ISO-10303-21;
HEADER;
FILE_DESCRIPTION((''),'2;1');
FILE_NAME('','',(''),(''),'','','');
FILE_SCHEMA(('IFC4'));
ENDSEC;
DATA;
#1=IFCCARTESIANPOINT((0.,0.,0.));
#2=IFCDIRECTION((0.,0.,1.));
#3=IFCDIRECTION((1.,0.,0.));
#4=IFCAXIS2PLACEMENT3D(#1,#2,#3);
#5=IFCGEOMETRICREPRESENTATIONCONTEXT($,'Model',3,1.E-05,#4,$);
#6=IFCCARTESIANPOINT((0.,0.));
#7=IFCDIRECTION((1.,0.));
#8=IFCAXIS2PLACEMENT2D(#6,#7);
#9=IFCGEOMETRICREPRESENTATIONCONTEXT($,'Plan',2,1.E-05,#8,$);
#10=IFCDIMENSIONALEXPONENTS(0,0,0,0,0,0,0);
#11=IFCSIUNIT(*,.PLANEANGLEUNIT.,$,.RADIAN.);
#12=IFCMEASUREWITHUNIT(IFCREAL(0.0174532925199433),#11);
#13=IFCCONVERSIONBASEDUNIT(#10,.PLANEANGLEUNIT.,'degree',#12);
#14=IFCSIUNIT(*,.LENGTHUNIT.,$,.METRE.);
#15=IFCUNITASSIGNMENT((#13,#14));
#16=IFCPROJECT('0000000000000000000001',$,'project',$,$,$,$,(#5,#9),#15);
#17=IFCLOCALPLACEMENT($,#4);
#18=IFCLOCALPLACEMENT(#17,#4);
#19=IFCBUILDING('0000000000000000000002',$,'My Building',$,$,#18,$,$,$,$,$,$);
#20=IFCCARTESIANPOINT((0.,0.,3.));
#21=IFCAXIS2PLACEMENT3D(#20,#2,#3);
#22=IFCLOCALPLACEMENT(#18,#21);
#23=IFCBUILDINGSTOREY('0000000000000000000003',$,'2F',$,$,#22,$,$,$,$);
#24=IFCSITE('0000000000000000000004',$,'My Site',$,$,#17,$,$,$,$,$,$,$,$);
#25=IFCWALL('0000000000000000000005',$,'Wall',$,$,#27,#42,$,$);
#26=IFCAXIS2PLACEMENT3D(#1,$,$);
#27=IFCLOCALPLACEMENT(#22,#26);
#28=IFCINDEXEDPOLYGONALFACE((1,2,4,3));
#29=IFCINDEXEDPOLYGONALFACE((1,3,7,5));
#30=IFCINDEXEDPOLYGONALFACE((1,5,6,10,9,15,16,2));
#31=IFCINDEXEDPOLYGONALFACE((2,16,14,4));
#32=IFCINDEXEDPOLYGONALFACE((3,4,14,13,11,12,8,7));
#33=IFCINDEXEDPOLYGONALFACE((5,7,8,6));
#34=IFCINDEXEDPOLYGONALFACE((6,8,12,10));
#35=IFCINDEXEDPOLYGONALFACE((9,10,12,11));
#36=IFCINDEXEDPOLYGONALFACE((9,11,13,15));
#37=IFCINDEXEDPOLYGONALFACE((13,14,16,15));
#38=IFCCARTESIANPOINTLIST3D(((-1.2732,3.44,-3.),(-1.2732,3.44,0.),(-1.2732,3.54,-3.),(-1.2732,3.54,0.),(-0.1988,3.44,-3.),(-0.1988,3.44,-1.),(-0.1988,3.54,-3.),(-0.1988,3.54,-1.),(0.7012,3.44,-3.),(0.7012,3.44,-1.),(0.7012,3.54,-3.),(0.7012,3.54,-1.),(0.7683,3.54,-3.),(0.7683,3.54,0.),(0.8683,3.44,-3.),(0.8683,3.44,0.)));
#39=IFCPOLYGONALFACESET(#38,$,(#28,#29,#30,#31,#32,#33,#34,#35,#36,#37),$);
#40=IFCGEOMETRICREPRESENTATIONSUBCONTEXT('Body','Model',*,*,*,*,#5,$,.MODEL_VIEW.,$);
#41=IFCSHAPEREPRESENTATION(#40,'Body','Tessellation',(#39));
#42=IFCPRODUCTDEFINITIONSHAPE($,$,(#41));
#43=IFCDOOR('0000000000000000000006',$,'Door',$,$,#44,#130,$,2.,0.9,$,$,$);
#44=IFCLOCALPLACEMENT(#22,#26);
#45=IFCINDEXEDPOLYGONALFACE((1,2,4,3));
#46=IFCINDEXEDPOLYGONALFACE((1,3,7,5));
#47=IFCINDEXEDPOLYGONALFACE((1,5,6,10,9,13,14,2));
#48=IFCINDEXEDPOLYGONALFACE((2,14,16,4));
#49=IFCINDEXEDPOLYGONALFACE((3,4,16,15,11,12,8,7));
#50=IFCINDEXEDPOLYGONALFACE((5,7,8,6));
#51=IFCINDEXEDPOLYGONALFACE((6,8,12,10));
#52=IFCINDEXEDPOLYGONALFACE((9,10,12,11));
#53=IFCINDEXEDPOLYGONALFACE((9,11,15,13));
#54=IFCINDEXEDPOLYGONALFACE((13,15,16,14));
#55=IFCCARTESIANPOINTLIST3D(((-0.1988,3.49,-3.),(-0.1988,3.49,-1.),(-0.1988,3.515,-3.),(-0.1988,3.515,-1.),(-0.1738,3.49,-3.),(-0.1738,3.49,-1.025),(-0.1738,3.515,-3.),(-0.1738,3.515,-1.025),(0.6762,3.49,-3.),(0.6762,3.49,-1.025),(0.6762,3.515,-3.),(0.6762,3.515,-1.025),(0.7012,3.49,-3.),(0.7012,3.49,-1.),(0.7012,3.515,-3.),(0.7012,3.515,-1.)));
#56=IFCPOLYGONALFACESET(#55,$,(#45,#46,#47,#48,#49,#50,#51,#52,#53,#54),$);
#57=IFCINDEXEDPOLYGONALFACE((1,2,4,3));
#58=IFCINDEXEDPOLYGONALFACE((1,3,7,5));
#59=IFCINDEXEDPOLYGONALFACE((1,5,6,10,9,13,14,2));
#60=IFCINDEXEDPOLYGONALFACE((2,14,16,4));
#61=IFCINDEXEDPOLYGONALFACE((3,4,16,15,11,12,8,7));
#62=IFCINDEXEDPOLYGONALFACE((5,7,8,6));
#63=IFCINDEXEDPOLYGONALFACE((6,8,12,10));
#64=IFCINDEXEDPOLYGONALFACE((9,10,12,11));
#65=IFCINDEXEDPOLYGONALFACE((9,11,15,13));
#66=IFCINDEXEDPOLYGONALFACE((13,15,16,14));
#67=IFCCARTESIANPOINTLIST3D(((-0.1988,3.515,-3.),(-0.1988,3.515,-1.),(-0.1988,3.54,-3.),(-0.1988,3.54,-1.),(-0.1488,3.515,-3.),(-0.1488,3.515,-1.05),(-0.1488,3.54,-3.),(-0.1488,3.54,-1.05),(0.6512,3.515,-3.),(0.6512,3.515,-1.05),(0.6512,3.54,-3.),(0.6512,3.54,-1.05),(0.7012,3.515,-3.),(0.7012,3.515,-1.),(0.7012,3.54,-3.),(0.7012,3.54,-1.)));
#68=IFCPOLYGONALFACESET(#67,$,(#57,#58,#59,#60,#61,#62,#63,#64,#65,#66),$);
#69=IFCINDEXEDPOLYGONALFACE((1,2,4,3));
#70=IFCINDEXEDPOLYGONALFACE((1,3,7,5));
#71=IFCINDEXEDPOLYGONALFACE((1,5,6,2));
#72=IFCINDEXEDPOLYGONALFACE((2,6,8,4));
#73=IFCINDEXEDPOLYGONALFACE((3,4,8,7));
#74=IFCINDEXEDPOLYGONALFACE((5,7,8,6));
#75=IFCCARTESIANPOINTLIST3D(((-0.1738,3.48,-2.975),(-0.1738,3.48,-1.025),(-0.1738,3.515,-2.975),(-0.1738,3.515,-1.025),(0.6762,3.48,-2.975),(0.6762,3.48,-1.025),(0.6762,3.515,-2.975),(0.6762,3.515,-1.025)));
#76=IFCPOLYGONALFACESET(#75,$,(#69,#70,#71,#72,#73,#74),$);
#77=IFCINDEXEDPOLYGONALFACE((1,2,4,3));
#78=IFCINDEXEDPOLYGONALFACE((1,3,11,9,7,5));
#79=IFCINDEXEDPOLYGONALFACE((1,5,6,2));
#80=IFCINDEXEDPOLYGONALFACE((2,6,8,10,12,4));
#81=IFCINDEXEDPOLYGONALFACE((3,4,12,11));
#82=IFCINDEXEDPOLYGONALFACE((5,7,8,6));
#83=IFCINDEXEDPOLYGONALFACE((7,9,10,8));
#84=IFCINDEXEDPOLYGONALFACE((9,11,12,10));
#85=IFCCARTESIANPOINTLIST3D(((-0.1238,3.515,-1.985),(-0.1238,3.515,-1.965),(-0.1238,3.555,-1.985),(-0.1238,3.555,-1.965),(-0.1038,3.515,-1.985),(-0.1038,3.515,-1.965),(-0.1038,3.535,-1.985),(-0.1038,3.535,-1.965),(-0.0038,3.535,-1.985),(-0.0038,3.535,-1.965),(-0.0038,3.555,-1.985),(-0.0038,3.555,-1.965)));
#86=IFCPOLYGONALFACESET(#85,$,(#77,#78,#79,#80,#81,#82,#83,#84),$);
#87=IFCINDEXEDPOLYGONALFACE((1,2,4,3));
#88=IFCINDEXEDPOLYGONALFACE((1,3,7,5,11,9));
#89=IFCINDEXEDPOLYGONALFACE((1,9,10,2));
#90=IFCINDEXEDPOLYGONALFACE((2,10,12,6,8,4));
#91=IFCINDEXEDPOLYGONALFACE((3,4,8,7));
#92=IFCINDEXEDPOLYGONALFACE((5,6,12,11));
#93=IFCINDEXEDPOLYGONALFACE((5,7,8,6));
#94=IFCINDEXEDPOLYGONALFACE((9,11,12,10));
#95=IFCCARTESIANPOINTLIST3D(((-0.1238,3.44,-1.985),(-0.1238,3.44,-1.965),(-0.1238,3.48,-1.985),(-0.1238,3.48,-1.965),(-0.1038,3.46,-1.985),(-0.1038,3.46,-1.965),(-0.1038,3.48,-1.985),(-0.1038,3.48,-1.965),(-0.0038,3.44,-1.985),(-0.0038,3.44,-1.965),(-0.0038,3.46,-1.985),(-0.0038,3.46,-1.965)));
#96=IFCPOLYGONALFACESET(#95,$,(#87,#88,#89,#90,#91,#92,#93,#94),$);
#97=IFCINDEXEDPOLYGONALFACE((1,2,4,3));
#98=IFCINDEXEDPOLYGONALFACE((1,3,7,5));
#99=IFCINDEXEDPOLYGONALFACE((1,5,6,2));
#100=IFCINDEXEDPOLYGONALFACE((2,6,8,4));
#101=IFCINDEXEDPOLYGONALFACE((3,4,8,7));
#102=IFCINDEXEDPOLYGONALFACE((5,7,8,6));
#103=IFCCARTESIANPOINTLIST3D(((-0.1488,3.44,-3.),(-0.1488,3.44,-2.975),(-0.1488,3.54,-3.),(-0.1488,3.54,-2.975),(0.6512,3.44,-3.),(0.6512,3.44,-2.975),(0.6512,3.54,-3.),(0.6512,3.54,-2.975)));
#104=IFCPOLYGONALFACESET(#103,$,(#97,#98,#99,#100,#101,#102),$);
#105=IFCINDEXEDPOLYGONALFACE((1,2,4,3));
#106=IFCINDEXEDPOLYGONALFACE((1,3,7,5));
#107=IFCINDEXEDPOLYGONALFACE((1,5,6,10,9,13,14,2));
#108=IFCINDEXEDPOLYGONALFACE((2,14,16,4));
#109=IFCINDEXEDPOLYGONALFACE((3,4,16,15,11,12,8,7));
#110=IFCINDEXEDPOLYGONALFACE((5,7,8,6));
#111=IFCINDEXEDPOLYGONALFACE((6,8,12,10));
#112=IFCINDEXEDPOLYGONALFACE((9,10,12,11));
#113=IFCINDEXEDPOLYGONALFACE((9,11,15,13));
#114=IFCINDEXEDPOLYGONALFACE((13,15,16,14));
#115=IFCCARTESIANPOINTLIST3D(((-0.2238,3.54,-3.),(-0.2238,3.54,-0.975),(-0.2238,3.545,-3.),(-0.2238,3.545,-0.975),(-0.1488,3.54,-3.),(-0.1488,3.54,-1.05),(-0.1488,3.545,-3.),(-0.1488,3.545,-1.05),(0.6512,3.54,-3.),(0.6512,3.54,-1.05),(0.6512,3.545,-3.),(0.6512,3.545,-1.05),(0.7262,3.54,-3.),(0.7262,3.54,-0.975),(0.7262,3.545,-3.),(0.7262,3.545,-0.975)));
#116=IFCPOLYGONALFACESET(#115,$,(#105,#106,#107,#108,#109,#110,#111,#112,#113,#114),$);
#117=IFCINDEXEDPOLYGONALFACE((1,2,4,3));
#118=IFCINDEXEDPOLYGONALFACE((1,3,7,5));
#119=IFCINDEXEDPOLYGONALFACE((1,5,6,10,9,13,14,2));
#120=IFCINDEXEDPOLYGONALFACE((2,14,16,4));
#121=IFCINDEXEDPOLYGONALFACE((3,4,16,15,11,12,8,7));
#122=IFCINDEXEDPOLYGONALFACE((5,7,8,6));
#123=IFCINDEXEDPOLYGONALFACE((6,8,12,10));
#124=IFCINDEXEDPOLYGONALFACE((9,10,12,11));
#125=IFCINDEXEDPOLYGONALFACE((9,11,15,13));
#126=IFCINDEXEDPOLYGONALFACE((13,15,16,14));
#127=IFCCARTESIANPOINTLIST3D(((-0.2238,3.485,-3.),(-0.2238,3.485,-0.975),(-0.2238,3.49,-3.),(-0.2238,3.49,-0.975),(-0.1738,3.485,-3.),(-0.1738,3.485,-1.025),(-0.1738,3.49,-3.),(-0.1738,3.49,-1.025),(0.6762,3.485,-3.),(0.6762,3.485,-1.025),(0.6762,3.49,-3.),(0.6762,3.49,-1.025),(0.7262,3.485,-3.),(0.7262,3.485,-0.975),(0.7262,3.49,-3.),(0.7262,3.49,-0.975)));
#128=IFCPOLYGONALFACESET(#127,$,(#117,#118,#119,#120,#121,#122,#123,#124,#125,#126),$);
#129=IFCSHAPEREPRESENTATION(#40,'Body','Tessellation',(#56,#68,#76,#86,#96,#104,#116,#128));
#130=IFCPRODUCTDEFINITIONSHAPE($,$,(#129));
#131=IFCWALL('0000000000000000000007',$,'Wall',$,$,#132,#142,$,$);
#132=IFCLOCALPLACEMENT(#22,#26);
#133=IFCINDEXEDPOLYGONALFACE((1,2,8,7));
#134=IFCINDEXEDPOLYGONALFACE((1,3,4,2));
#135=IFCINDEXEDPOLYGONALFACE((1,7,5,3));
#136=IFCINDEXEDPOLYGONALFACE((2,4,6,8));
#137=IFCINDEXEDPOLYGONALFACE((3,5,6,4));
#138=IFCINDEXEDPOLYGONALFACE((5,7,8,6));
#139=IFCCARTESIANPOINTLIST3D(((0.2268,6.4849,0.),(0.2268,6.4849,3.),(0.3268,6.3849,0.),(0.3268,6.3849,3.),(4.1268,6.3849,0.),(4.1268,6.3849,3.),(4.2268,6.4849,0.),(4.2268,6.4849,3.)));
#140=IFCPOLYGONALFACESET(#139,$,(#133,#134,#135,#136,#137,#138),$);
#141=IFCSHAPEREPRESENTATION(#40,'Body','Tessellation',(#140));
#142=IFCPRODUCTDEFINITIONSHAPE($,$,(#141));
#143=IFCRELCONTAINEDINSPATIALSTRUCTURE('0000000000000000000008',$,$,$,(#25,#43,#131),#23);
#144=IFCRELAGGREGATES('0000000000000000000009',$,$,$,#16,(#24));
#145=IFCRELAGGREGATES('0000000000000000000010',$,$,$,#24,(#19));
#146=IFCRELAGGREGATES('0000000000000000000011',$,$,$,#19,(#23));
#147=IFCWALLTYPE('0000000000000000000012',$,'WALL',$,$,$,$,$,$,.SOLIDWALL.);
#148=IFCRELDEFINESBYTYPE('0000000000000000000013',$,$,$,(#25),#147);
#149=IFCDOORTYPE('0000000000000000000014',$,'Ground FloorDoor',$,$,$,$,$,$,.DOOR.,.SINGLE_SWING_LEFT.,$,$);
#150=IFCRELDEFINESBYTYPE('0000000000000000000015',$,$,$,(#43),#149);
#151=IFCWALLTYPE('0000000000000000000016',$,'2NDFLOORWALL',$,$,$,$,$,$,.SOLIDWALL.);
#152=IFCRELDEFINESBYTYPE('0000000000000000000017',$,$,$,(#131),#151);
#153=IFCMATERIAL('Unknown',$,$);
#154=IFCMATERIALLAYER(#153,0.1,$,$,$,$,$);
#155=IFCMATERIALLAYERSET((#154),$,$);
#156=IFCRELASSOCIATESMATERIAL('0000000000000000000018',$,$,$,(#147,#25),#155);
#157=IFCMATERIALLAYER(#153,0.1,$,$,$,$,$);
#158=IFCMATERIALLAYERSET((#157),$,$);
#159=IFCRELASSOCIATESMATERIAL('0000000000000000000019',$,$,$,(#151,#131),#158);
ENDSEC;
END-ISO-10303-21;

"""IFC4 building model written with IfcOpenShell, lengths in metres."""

from ifc_helpers import new_model, entity, si_unit, converted_unit, frame, origin_with_axes, origin_2d_with_axis, place, context, subcontext, project, spatial, line, indexed_curve, outline, extrude, shape, source, transform, mapped, material, layer, layer_set, layer_usage, type_object, type_shapes, element, fill, save


model = new_model("IFC4")

# Units and contexts
model_context = context("Model", 3, precision=1e-05, world=origin_with_axes())
plan_context = context("Plan", 2, precision=1e-05, world=origin_2d_with_axis())
body_context_1 = subcontext(model_context, "Body", "Model", "MODEL_VIEW")
body_context_2 = subcontext(plan_context, "Body", "Plan", "PLAN_VIEW")
ifc_project = project(units=[converted_unit("PLANEANGLEUNIT", "degree", entity("IfcReal", 0.0174532925199433), si_unit("PLANEANGLEUNIT", "RADIAN"), dimensions=[0, 0, 0, 0, 0, 0, 0]), si_unit("LENGTHUNIT", "METRE")], contexts=[model_context, plan_context])

# Site, building, storey
site_placement = place(None, origin_with_axes())
site = spatial("IfcSite", under=ifc_project, at=site_placement, Name="My Site")
building_placement = place(site_placement, origin_with_axes())
building = spatial("IfcBuilding", under=site, at=building_placement, Name="My Building")
storey_placement = place(building_placement, frame((0.0, 0.0, 3.0), z_axis=(0.0, 0.0, 1.0), x_axis=(1.0, 0.0, 0.0)))
storey = spatial("IfcBuildingStorey", under=building, at=storey_placement, Name="2F")

# Shared definitions
ifc_material = material(Name="Unknown")
ifc_layer_1 = layer(ifc_material, 0.1)
ifc_layer_set_1 = layer_set([ifc_layer_1])
wall_type_1 = type_object("IfcWallType", Name="WALL", PredefinedType="SOLIDWALL", material=ifc_layer_set_1)

# Shared definitions
shared_shape_1 = source(origin_with_axes(), body_context_1, "Body", "SweptSolid", [
    extrude(outline(indexed_curve([(0.0, 0.0), (0.9, 0.0), (0.9, 2.0), (0.0, 2.0)], segments=[line(1, 2, 3, 4, 1)])), frame((0.0, -0.6, 0.0), z_axis=(0.0, -1.0, 0.0), x_axis=(1.0, 0.0, 0.0)), (0.0, 0.0, -1.0), 1.2),
])
door_type_1 = type_object("IfcDoorType", Name="Ground FloorDoor", OperationType="SINGLE_SWING_LEFT", PredefinedType="DOOR")
shared_shape_2 = source(origin_with_axes(), body_context_1, "Body", "SweptSolid", [
    extrude(outline(indexed_curve([(0.0, 0.0), (0.0, 2.0), (0.9, 2.0), (0.9, 0.0), (0.875, 0.0), (0.875, 1.975), (0.025, 1.975), (0.025, 0.0)], segments=[line(1, 2, 3, 4, 5, 6, 7, 8, 1)])), frame((0.0, 0.025, 0.0), z_axis=(0.0, -1.0, 0.0), x_axis=(1.0, 0.0, 0.0)), (0.0, 0.0, -1.0), 0.025),
    extrude(outline(indexed_curve([(0.0, 0.0), (0.0, 2.0), (0.9, 2.0), (0.9, 0.0), (0.85, 0.0), (0.85, 1.95), (0.05, 1.95), (0.05, 0.0)], segments=[line(1, 2, 3, 4, 5, 6, 7, 8, 1)])), frame((0.0, 0.0, 0.0), z_axis=(0.0, -1.0, 0.0), x_axis=(1.0, 0.0, 0.0)), (0.0, 0.0, -1.0), 0.025),
    extrude(outline(indexed_curve([(0.0, 0.0), (0.85, 0.0), (0.85, 0.035), (0.0, 0.035)], segments=[line(1, 2, 3, 4, 1)])), frame((0.025, 0.025, 0.025), z_axis=(0.0, 0.0, 1.0), x_axis=(1.0, 0.0, 0.0)), (0.0, 0.0, 1.0), 1.95),
    extrude(outline(indexed_curve([(0.0, 0.0), (0.0, -0.04), (-0.12, -0.04), (-0.12, -0.02), (-0.02, -0.02), (-0.02, 0.0)], segments=[line(1, 2, 3, 4, 5, 6, 1)])), frame((0.825, 0.025, 1.015), z_axis=(0.0, 0.0, 1.0), x_axis=(1.0, 0.0, 0.0)), (0.0, 0.0, 1.0), 0.02),
    extrude(outline(indexed_curve([(0.0, 0.0), (0.0, 0.04), (-0.12, 0.04), (-0.12, 0.02), (-0.02, 0.02), (-0.02, 0.0)], segments=[line(1, 2, 3, 4, 5, 6, 1)])), frame((0.825, 0.06, 1.015), z_axis=(0.0, 0.0, 1.0), x_axis=(1.0, 0.0, 0.0)), (0.0, 0.0, 1.0), 0.02),
    extrude(outline(indexed_curve([(0.0, 0.0), (0.8, 0.0), (0.8, 0.1), (0.0, 0.1)], segments=[line(1, 2, 3, 4, 1)])), frame((0.05, 0.0, 0.0), z_axis=(0.0, 0.0, 1.0), x_axis=(1.0, 0.0, 0.0)), (0.0, 0.0, 1.0), 0.025),
    extrude(outline(indexed_curve([(0.0, 0.0), (0.0, 2.025), (0.95, 2.025), (0.95, 0.0), (0.875, 0.0), (0.875, 1.95), (0.075, 1.95), (0.075, 0.0)], segments=[line(1, 2, 3, 4, 5, 6, 7, 8, 1)])), frame((-0.025, -0.005, 0.0), z_axis=(0.0, -1.0, 0.0), x_axis=(1.0, 0.0, 0.0)), (0.0, 0.0, -1.0), 0.005),
    extrude(outline(indexed_curve([(0.0, 0.0), (0.0, 2.025), (0.95, 2.025), (0.95, 0.0), (0.9, 0.0), (0.9, 1.975), (0.05, 1.975), (0.05, 0.0)], segments=[line(1, 2, 3, 4, 5, 6, 7, 8, 1)])), frame((-0.025, 0.05, 0.0), z_axis=(0.0, -1.0, 0.0), x_axis=(1.0, 0.0, 0.0)), (0.0, 0.0, -1.0), 0.005),
])
shared_shape_3 = source(origin_with_axes(), body_context_2, "Body", "Curve2D", [
    entity("IfcIndexedPolyCurve", entity("IfcCartesianPointList2D", [[0.0, 0.0], [0.0, 0.05], [0.025, 0.05], [0.025, 0.025], [0.05, 0.025], [0.05, 0.0]]), [entity("IfcLineIndex", [1, 2, 3, 4, 5, 6, 1])]),
    entity("IfcIndexedPolyCurve", entity("IfcCartesianPointList2D", [[0.9, 0.0], [0.9, 0.05], [0.875, 0.05], [0.875, 0.025], [0.85, 0.025], [0.85, 0.0]]), [entity("IfcLineIndex", [1, 2, 3, 4, 5, 6, 1])]),
    entity("IfcTrimmedCurve", entity("IfcEllipse", entity("IfcAxis2Placement2D", entity("IfcCartesianPoint", [0.06, 0.05]), entity("IfcDirection", [1.0, 0.0])), 0.815, 0.85), [entity("IfcCartesianPoint", [0.875, 0.05])], [entity("IfcCartesianPoint", [0.06, 0.9])], True, "CARTESIAN"),
    entity("IfcIndexedPolyCurve", entity("IfcCartesianPointList2D", [[0.025, 0.05], [0.06, 0.05], [0.06, 0.9], [0.025, 0.9]]), [entity("IfcLineIndex", [1, 2, 3, 4, 1])]),
])
type_shapes(door_type_1, [shared_shape_2, shared_shape_3])

# Wall, opening, door
ifc_layer_usage_1 = layer_usage(ifc_layer_set_1, "AXIS2", "POSITIVE", 0.0)
wall_1_placement = place(storey_placement, frame((0.7683, 3.54, -3.0), z_axis=(0.0, 0.0, 1.0), x_axis=(-1.0, 0.0, 0.0)))
wall_1 = element("IfcWall", 1, at=wall_1_placement, inside=storey, type_object=wall_type_1, material=ifc_layer_usage_1, Name="Wall", context=body_context_1, shape_type="SweptSolid", body=[
    extrude(outline(indexed_curve([(0.0, 0.0), (-0.1, 0.1), (2.0415, 0.1), (2.0415, 0.0)], segments=[line(1, 2, 3, 4, 1)])), origin_with_axes(), (0.0, 0.0, 1.0), 3.0),
])
opening_1_placement = place(wall_1_placement, frame((0.0671, 0.0, 0.0), z_axis=(0.0, 0.0, 1.0), x_axis=(1.0, 0.0, 0.0)))
opening_1 = element("IfcOpeningElement", 2, at=opening_1_placement, cuts=wall_1, PredefinedType="OPENING", context=body_context_1, shape_type="MappedRepresentation", body=[
    mapped(shared_shape_1, transform((0.0, 0.0, 0.0), x_axis=(1.0, 0.0, 0.0), y_axis=(0.0, 1.0, 0.0), z_axis=(0.0, 0.0, 1.0), scale=1.0)),
])
door_1_placement = place(opening_1_placement, frame((0.0, 0.0, 0.0), z_axis=(0.0, 0.0, 1.0), x_axis=(1.0, 0.0, 0.0)))
door_1 = element("IfcDoor", 3, at=door_1_placement, inside=storey, type_object=door_type_1, Name="Door", OverallHeight=2.0, OverallWidth=0.9, shapes=[
    shape(body_context_1, "Body", "MappedRepresentation", [mapped(shared_shape_2, transform((0.0, 0.0, 0.0), x_axis=(1.0, 0.0, 0.0), y_axis=(0.0, 1.0, 0.0), z_axis=(0.0, 0.0, 1.0), scale=1.0))]),
    shape(body_context_2, "Body", "MappedRepresentation", [mapped(shared_shape_3, transform((0.0, 0.0, 0.0), x_axis=(1.0, 0.0, 0.0), y_axis=(0.0, 1.0, 0.0), z_axis=(0.0, 0.0, 1.0), scale=1.0))]),
])
fill(opening_1, door_1)

# Wall
ifc_layer_2 = layer(ifc_material, 0.1)
ifc_layer_set_2 = layer_set([ifc_layer_2])
ifc_layer_usage_2 = layer_usage(ifc_layer_set_2, "AXIS2", "POSITIVE", 0.0)
wall_type_2 = type_object("IfcWallType", Name="2NDFLOORWALL", PredefinedType="SOLIDWALL", material=ifc_layer_set_2)
wall_2_placement = place(storey_placement, frame((4.2268, 6.4849, 0.0), z_axis=(0.0, 0.0, 1.0), x_axis=(-1.0, 0.0, 0.0)))
element("IfcWall", 4, at=wall_2_placement, inside=storey, type_object=wall_type_2, material=ifc_layer_usage_2, Name="Wall", context=body_context_1, shape_type="SweptSolid", body=[
    extrude(outline(indexed_curve([(0.0, 0.0), (0.1, 0.1), (3.9, 0.1), (4.0, 0.0)], segments=[line(1, 2, 3, 4, 1)])), origin_with_axes(), (0.0, 0.0, 1.0), 3.0),
])

save(model, "model.ifc")
